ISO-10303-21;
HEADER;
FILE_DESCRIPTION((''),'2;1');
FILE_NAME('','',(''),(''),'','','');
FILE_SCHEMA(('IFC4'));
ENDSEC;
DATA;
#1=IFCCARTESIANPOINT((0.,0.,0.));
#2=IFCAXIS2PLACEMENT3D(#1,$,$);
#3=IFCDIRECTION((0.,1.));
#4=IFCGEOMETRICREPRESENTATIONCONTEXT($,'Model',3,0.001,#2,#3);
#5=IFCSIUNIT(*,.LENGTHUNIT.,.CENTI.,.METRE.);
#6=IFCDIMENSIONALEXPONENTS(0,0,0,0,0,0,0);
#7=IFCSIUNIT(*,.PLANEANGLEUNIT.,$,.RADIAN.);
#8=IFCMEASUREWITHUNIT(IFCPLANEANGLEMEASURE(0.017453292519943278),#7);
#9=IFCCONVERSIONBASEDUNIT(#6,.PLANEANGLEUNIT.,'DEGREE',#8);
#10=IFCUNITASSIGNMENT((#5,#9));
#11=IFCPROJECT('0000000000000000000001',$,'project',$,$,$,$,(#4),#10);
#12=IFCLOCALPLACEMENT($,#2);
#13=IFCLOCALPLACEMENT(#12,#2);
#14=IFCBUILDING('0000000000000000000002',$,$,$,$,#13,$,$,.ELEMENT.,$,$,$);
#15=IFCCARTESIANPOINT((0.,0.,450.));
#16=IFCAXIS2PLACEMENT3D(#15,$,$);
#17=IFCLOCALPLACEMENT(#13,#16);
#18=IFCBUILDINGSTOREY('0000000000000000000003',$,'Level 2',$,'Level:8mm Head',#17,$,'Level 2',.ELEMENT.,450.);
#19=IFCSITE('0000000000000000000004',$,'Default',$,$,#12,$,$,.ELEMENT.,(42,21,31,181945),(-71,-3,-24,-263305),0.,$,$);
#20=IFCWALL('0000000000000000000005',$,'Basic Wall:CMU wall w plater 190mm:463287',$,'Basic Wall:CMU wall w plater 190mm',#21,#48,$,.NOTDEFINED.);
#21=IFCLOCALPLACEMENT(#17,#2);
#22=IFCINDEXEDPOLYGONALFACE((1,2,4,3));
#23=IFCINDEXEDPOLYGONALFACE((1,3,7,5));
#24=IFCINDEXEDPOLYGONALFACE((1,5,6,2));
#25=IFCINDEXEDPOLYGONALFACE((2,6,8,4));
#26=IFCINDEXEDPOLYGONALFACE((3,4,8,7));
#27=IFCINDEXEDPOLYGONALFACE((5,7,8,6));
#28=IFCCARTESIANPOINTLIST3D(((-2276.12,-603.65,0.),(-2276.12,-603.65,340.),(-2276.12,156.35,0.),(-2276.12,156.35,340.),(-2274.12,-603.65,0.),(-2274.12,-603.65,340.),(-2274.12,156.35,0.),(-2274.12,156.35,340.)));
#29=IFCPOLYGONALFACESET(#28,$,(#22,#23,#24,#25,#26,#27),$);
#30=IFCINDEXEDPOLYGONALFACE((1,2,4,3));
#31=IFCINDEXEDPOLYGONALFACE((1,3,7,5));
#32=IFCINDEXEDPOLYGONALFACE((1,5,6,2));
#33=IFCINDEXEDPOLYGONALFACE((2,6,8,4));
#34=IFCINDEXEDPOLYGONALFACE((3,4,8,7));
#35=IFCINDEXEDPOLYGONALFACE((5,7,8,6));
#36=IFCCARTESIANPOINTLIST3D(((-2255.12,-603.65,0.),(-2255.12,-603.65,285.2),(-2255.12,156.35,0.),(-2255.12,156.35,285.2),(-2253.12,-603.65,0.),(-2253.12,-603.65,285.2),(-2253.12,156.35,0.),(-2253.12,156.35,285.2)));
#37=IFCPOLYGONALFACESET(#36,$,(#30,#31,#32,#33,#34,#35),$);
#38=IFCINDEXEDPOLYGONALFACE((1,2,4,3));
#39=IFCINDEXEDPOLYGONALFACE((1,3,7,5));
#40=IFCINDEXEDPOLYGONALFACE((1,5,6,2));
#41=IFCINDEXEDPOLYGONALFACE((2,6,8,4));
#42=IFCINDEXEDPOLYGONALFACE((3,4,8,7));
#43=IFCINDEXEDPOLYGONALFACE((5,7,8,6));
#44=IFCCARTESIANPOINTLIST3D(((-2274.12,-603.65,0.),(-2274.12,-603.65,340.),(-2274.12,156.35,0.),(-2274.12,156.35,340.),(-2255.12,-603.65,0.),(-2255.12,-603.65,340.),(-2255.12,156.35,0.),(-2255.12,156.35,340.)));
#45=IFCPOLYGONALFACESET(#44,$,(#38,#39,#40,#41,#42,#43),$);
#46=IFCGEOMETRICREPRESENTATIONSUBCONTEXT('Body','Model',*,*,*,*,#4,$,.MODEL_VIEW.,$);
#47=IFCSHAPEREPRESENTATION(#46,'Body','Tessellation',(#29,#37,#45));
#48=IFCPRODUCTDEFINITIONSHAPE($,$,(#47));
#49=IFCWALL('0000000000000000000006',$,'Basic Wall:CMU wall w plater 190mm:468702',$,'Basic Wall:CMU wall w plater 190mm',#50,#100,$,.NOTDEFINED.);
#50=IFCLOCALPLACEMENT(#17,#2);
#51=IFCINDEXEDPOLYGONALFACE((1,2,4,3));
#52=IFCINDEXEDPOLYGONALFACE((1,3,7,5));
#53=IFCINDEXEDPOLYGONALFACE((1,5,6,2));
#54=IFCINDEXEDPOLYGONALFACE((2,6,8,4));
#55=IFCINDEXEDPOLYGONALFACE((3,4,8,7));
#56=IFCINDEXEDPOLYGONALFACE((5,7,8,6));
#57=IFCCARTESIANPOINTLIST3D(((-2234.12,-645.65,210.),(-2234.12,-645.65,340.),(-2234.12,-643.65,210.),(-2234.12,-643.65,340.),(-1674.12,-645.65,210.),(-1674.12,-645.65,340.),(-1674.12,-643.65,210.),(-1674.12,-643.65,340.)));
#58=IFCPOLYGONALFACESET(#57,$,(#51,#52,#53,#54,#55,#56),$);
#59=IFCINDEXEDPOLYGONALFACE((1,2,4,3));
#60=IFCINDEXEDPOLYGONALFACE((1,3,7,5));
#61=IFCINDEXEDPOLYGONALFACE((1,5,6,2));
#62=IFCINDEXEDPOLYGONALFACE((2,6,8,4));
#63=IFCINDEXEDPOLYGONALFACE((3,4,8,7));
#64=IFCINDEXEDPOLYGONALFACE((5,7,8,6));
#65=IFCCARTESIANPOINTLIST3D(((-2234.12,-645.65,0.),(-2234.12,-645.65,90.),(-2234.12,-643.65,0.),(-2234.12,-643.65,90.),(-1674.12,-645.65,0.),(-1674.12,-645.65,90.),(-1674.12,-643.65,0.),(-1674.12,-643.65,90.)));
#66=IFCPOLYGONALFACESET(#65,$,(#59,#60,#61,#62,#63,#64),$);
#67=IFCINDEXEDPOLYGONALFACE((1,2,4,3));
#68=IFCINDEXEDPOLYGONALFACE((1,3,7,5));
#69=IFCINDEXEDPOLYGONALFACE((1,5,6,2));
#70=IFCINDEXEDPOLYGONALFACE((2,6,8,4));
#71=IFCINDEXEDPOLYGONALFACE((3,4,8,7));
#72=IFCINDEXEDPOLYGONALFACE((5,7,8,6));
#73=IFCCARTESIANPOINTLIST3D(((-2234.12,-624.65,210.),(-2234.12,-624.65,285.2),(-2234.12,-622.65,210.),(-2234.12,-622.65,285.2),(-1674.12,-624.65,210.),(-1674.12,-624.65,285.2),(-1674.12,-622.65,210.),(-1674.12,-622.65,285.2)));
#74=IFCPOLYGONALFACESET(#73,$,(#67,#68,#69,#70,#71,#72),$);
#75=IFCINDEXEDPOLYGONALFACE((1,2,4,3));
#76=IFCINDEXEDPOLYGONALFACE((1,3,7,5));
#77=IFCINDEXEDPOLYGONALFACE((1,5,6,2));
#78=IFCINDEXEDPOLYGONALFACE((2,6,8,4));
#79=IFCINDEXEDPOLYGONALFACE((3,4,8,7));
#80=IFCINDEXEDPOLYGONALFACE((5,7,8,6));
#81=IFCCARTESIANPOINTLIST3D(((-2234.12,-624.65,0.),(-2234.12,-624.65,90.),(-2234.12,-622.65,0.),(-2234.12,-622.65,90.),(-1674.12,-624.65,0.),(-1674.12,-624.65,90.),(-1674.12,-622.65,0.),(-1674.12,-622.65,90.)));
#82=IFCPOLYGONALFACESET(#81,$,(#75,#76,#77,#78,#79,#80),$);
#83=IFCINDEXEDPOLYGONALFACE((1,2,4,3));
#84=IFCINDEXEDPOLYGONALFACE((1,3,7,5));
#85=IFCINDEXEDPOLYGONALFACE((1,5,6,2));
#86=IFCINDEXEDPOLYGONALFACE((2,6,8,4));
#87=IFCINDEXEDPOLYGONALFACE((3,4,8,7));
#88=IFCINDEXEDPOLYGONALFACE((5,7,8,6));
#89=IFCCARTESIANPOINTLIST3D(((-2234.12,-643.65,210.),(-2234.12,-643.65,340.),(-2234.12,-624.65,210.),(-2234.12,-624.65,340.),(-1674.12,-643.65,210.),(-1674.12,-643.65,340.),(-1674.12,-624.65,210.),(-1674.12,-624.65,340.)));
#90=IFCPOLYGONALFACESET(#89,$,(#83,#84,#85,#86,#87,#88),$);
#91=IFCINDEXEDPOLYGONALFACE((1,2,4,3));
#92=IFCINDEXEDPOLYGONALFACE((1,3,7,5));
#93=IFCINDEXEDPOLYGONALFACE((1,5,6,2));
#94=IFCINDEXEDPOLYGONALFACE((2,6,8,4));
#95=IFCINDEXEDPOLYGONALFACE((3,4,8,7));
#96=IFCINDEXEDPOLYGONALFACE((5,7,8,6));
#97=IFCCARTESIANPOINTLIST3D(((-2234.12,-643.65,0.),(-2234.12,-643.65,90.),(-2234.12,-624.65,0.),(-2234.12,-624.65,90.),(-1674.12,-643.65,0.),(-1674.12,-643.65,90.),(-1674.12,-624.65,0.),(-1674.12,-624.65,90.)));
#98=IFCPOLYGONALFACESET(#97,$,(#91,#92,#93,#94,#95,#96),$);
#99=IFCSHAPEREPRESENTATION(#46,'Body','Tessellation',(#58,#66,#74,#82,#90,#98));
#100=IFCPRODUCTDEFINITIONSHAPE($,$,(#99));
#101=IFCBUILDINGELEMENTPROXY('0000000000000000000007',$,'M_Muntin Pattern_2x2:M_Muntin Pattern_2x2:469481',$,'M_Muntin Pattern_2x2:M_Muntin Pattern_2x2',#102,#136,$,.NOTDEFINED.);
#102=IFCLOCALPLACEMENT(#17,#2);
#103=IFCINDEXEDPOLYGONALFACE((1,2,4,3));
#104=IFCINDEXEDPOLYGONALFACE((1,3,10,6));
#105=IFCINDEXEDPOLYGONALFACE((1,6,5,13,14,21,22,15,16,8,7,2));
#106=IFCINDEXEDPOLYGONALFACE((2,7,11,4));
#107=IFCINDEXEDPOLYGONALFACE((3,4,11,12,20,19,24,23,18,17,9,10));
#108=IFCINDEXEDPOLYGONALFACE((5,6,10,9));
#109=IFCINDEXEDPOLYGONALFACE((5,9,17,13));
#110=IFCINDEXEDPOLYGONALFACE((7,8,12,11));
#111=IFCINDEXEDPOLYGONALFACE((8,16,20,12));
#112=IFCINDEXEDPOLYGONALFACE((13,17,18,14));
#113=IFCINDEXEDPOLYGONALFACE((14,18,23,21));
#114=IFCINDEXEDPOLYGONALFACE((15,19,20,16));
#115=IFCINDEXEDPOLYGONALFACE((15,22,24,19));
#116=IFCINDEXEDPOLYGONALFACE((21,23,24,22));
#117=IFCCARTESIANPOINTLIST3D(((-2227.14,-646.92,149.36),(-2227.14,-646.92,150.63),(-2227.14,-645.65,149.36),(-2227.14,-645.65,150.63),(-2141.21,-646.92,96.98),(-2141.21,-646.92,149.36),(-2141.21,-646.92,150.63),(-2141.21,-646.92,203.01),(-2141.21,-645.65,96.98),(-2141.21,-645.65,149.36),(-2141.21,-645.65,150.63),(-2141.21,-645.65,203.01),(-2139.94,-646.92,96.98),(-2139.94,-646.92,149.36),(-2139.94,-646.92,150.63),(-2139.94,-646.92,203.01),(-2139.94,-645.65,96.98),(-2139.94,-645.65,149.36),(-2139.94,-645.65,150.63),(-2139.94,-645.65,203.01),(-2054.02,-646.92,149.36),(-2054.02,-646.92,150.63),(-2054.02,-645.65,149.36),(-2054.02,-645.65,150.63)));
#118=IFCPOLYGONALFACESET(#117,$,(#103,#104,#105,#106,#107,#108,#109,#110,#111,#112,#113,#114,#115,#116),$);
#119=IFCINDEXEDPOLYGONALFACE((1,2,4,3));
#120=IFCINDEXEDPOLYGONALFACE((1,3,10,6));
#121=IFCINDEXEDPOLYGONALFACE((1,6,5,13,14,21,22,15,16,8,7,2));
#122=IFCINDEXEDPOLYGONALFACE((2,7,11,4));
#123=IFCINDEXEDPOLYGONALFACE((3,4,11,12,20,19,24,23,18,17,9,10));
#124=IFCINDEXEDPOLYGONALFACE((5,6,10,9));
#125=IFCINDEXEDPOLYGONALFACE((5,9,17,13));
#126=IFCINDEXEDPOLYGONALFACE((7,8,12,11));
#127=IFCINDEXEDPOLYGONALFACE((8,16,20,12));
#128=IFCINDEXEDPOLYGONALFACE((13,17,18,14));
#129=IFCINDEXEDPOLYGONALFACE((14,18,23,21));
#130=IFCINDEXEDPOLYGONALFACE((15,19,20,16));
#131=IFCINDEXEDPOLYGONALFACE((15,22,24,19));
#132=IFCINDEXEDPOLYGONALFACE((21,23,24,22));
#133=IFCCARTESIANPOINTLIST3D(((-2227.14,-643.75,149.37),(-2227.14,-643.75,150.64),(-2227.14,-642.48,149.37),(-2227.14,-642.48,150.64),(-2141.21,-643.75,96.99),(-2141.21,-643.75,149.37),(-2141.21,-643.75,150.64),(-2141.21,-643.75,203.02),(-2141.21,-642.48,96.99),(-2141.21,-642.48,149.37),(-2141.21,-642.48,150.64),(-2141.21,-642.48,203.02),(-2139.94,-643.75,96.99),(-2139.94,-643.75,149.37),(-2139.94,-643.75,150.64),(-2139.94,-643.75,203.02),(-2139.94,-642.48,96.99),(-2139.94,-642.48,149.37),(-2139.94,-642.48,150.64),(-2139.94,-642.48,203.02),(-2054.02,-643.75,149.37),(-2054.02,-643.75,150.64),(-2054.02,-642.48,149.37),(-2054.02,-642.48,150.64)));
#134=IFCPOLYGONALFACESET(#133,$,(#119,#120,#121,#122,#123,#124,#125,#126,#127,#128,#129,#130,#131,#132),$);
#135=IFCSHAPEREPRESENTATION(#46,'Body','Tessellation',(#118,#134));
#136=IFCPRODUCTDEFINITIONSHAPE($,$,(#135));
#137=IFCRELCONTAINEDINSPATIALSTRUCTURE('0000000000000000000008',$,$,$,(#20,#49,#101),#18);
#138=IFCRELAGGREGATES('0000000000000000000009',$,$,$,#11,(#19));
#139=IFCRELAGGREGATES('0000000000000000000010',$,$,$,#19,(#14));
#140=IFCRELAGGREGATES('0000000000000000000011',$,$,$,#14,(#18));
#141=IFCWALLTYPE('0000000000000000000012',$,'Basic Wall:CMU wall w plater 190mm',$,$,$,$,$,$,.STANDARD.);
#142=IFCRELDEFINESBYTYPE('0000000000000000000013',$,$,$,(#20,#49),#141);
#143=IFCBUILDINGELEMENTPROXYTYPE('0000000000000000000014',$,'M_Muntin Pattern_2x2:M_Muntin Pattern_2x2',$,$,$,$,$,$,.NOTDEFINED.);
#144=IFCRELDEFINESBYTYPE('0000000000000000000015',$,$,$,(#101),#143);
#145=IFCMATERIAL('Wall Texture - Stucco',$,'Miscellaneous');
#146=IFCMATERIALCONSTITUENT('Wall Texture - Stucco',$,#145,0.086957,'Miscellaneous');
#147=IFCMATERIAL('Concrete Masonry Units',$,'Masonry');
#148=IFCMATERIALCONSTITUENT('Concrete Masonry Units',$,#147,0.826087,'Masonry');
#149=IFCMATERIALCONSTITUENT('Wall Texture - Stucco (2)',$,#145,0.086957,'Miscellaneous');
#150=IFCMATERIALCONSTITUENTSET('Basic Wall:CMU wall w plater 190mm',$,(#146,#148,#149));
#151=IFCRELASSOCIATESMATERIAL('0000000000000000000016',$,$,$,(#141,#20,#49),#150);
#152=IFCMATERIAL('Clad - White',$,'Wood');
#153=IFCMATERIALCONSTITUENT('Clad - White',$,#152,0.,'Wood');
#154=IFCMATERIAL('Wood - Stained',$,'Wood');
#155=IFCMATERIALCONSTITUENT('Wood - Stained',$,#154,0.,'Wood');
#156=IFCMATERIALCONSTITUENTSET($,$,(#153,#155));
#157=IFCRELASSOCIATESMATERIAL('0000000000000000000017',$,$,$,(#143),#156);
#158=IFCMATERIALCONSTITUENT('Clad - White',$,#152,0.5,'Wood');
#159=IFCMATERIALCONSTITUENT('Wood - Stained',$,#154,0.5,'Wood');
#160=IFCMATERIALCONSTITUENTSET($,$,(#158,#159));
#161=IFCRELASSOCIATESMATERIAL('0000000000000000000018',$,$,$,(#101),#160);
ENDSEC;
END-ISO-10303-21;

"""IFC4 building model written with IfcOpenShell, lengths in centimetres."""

from ifc_helpers import new_model, entity, si_unit, converted_unit, direction, frame, origin, place, context, subcontext, project, spatial, indexed_curve, outline, extrude, source, transform, mapped, material, constituent, constituent_set, type_object, type_shapes, element, save


model = new_model("IFC4")

# Units and contexts
model_context = context("Model", 3, precision=0.001, world=origin(), true_north=direction((0.0, 1.0)))
body_context = subcontext(model_context, "Body", "Model", "MODEL_VIEW")
ifc_project = project(units=[si_unit("LENGTHUNIT", "METRE", prefix="CENTI"), converted_unit("PLANEANGLEUNIT", "DEGREE", entity("IfcPlaneAngleMeasure", 0.017453292519943278), si_unit("PLANEANGLEUNIT", "RADIAN"), dimensions=[0, 0, 0, 0, 0, 0, 0])], contexts=[model_context])

# Site, building, storey
site_placement = place(None, origin())
site = spatial("IfcSite", under=ifc_project, at=site_placement, Name="Default", CompositionType="ELEMENT", RefLatitude=(42, 21, 31, 181945), RefLongitude=(-71, -3, -24, -263305), RefElevation=0.0)
building_placement = place(site_placement, origin())
building = spatial("IfcBuilding", under=site, at=building_placement, CompositionType="ELEMENT")
storey_placement = place(building_placement, frame((0.0, 0.0, 450.0)))
storey = spatial("IfcBuildingStorey", under=building, at=storey_placement, Name="Level 2", ObjectType="Level:8mm Head", LongName="Level 2", CompositionType="ELEMENT", Elevation=450.0)

# Wall
ifc_material_1 = material(Name="Wall Texture - Stucco", Category="Miscellaneous")
ifc_constituent_1 = constituent(ifc_material_1, Name="Wall Texture - Stucco", Category="Miscellaneous", fraction=0.086957)
ifc_material_2 = material(Name="Concrete Masonry Units", Category="Masonry")
ifc_constituent_2 = constituent(ifc_material_2, Name="Concrete Masonry Units", Category="Masonry", fraction=0.826087)
ifc_constituent_3 = constituent(ifc_material_1, Name="Wall Texture - Stucco (2)", Category="Miscellaneous", fraction=0.086957)
ifc_constituent_set_1 = constituent_set(constituents=[ifc_constituent_1, ifc_constituent_2, ifc_constituent_3], Name="Basic Wall:CMU wall w plater 190mm")
wall_type_1 = type_object("IfcWallType", Name="Basic Wall:CMU wall w plater 190mm", PredefinedType="STANDARD", material=ifc_constituent_set_1)
wall_1_placement = place(storey_placement, frame((-2264.62, -603.65, 0.0), z_axis=(0.0, 0.0, 1.0), x_axis=(0.0, 1.0, 0.0)))
element("IfcWall", 1, at=wall_1_placement, inside=storey, type_object=wall_type_1, material=ifc_constituent_set_1, Name="Basic Wall:CMU wall w plater 190mm:463287", ObjectType="Basic Wall:CMU wall w plater 190mm", PredefinedType="NOTDEFINED", context=body_context, shape_type="SweptSolid", body=[
    extrude(outline(indexed_curve([(-1.0, -380.0), (1.0, -380.0), (1.0, 380.0), (-1.0, 380.0), (-1.0, -380.0)], self_intersect=False)), frame((380.0, 10.5, 0.0), z_axis=(0.0, 0.0, 1.0), x_axis=(0.0, -1.0, 0.0)), (0.0, 0.0, 1.0), 340.0),
    extrude(outline(indexed_curve([(-1.0, -380.0), (1.0, -380.0), (1.0, 380.0), (-1.0, 380.0), (-1.0, -380.0)], self_intersect=False)), frame((380.0, -10.5, 0.0), z_axis=(0.0, 0.0, 1.0), x_axis=(0.0, 1.0, 0.0)), (0.0, 0.0, 1.0), 285.2),
    extrude(outline(indexed_curve([(-380.0, -9.5), (380.0, -9.5), (380.0, 9.5), (-380.0, 9.5), (-380.0, -9.5)], self_intersect=False)), frame((380.0, 0.0, 0.0)), (0.0, 0.0, 1.0), 340.0),
])

# Wall, opening
wall_2_placement = place(storey_placement, frame((-2234.12, -634.15, 0.0)))
wall_2 = element("IfcWall", 2, at=wall_2_placement, inside=storey, type_object=wall_type_1, material=ifc_constituent_set_1, Name="Basic Wall:CMU wall w plater 190mm:468702", ObjectType="Basic Wall:CMU wall w plater 190mm", PredefinedType="NOTDEFINED", context=body_context, shape_type="SweptSolid", body=[
    extrude(outline(indexed_curve([(-278.0, -0.67), (278.0, -0.67), (280.0, -0.67), (280.0, 1.33), (-280.0, 1.33), (-280.0, -0.67), (-278.0, -0.67)], self_intersect=False)), frame((280.0, -10.83, 210.0)), (0.0, 0.0, 1.0), 130.0),
    extrude(outline(indexed_curve([(-1.0, -280.0), (1.0, -280.0), (1.0, 280.0), (-1.0, 280.0), (-1.0, -280.0)], self_intersect=False)), frame((280.0, -10.5, 0.0), z_axis=(0.0, 0.0, 1.0), x_axis=(0.0, 1.0, 0.0)), (0.0, 0.0, 1.0), 90.0),
    extrude(outline(indexed_curve([(-1.0, -37.6), (1.0, -37.6), (1.0, 37.6), (-1.0, 37.6), (-1.0, -37.6)], self_intersect=False)), frame((0.0, 10.5, 247.6), z_axis=(1.0, 0.0, 0.0), x_axis=(0.0, -1.0, 0.0)), (0.0, 0.0, 1.0), 560.0),
    extrude(outline(indexed_curve([(-1.0, -280.0), (1.0, -280.0), (1.0, 280.0), (-1.0, 280.0), (-1.0, -280.0)], self_intersect=False)), frame((280.0, 10.5, 0.0), z_axis=(0.0, 0.0, 1.0), x_axis=(0.0, -1.0, 0.0)), (0.0, 0.0, 1.0), 90.0),
    extrude(outline(indexed_curve([(-280.0, -9.5), (280.0, -9.5), (280.0, 9.5), (-280.0, 9.5), (-280.0, -9.5)], self_intersect=False)), frame((280.0, 0.0, 210.0), z_axis=(0.0, 0.0, 1.0), x_axis=(-1.0, 0.0, 0.0)), (0.0, 0.0, 1.0), 130.0),
    extrude(outline(indexed_curve([(-280.0, -9.5), (280.0, -9.5), (280.0, 9.5), (-280.0, 9.5), (-280.0, -9.5)], self_intersect=False)), frame((280.0, 0.0, 0.0)), (0.0, 0.0, 1.0), 90.0),
])
opening_1_placement = place(wall_2_placement, frame((560.0, 11.5, 90.0)))
element("IfcOpeningElement", 3, at=opening_1_placement, cuts=wall_2, PredefinedType="OPENING", context=body_context, shape_type="SweptSolid", body=[
    extrude(outline(indexed_curve([(120.0, 560.0), (0.0, 560.0), (0.0, 0.0), (120.0, 0.0), (120.0, 560.0)], self_intersect=False)), frame((0.0, 0.0, 0.0), z_axis=(0.0, -1.0, 0.0), x_axis=(0.0, 0.0, 1.0)), (0.0, 0.0, 1.0), 23.0),
])

# Building element proxy
ifc_material_3 = material(Name="Clad - White", Category="Wood")
ifc_constituent_4 = constituent(ifc_material_3, Name="Clad - White", Category="Wood", fraction=0.5)
ifc_material_4 = material(Name="Wood - Stained", Category="Wood")
ifc_constituent_5 = constituent(ifc_material_4, Name="Wood - Stained", Category="Wood", fraction=0.5)
ifc_constituent_set_2 = constituent_set(constituents=[ifc_constituent_4, ifc_constituent_5])
ifc_constituent_6 = constituent(ifc_material_3, Name="Clad - White", Category="Wood", fraction=0.0)
ifc_constituent_7 = constituent(ifc_material_4, Name="Wood - Stained", Category="Wood", fraction=0.0)
ifc_constituent_set_3 = constituent_set(constituents=[ifc_constituent_6, ifc_constituent_7])
building_element_proxy_type = type_object("IfcBuildingElementProxyType", Name="M_Muntin Pattern_2x2:M_Muntin Pattern_2x2", PredefinedType="NOTDEFINED", material=ifc_constituent_set_3)
shared_shape_1 = source(origin(), body_context, "Body", "SweptSolid", [
    extrude(outline(indexed_curve([(0.64, -0.64), (53.01, -0.64), (53.01, 0.63), (0.64, 0.63), (0.64, 86.56), (-0.63, 86.56), (-0.63, 0.63), (-53.02, 0.63), (-53.02, -0.64), (-0.63, -0.64), (-0.63, -86.56), (0.64, -86.56), (0.64, -0.64)], self_intersect=False)), frame((0.0, -2.22, 53.01), z_axis=(0.0, 1.0, 0.0), x_axis=(0.0, 0.0, 1.0)), (0.0, 0.0, 1.0), 1.27),
    extrude(outline(indexed_curve([(0.64, -0.64), (53.02, -0.64), (53.02, 0.63), (0.64, 0.63), (0.64, 86.56), (-0.63, 86.56), (-0.63, 0.63), (-53.02, 0.63), (-53.02, -0.64), (-0.63, -0.64), (-0.63, -86.56), (0.64, -86.56), (0.64, -0.64)], self_intersect=False)), frame((0.0, 0.95, 53.02), z_axis=(0.0, 1.0, 0.0), x_axis=(0.0, 0.0, 1.0)), (0.0, 0.0, 1.0), 1.27),
])
type_shapes(building_element_proxy_type, [shared_shape_1])
proxy_placement = place(storey_placement, frame((-2140.58, -644.7, 96.99)))
element("IfcBuildingElementProxy", 4, at=proxy_placement, inside=storey, type_object=building_element_proxy_type, material=ifc_constituent_set_2, Name="M_Muntin Pattern_2x2:M_Muntin Pattern_2x2:469481", ObjectType="M_Muntin Pattern_2x2:M_Muntin Pattern_2x2", PredefinedType="NOTDEFINED", context=body_context, shape_type="MappedRepresentation", body=[
    mapped(shared_shape_1, transform((0.0, 0.0, 0.0), scale=1.0)),
])

save(model, "model.ifc")
